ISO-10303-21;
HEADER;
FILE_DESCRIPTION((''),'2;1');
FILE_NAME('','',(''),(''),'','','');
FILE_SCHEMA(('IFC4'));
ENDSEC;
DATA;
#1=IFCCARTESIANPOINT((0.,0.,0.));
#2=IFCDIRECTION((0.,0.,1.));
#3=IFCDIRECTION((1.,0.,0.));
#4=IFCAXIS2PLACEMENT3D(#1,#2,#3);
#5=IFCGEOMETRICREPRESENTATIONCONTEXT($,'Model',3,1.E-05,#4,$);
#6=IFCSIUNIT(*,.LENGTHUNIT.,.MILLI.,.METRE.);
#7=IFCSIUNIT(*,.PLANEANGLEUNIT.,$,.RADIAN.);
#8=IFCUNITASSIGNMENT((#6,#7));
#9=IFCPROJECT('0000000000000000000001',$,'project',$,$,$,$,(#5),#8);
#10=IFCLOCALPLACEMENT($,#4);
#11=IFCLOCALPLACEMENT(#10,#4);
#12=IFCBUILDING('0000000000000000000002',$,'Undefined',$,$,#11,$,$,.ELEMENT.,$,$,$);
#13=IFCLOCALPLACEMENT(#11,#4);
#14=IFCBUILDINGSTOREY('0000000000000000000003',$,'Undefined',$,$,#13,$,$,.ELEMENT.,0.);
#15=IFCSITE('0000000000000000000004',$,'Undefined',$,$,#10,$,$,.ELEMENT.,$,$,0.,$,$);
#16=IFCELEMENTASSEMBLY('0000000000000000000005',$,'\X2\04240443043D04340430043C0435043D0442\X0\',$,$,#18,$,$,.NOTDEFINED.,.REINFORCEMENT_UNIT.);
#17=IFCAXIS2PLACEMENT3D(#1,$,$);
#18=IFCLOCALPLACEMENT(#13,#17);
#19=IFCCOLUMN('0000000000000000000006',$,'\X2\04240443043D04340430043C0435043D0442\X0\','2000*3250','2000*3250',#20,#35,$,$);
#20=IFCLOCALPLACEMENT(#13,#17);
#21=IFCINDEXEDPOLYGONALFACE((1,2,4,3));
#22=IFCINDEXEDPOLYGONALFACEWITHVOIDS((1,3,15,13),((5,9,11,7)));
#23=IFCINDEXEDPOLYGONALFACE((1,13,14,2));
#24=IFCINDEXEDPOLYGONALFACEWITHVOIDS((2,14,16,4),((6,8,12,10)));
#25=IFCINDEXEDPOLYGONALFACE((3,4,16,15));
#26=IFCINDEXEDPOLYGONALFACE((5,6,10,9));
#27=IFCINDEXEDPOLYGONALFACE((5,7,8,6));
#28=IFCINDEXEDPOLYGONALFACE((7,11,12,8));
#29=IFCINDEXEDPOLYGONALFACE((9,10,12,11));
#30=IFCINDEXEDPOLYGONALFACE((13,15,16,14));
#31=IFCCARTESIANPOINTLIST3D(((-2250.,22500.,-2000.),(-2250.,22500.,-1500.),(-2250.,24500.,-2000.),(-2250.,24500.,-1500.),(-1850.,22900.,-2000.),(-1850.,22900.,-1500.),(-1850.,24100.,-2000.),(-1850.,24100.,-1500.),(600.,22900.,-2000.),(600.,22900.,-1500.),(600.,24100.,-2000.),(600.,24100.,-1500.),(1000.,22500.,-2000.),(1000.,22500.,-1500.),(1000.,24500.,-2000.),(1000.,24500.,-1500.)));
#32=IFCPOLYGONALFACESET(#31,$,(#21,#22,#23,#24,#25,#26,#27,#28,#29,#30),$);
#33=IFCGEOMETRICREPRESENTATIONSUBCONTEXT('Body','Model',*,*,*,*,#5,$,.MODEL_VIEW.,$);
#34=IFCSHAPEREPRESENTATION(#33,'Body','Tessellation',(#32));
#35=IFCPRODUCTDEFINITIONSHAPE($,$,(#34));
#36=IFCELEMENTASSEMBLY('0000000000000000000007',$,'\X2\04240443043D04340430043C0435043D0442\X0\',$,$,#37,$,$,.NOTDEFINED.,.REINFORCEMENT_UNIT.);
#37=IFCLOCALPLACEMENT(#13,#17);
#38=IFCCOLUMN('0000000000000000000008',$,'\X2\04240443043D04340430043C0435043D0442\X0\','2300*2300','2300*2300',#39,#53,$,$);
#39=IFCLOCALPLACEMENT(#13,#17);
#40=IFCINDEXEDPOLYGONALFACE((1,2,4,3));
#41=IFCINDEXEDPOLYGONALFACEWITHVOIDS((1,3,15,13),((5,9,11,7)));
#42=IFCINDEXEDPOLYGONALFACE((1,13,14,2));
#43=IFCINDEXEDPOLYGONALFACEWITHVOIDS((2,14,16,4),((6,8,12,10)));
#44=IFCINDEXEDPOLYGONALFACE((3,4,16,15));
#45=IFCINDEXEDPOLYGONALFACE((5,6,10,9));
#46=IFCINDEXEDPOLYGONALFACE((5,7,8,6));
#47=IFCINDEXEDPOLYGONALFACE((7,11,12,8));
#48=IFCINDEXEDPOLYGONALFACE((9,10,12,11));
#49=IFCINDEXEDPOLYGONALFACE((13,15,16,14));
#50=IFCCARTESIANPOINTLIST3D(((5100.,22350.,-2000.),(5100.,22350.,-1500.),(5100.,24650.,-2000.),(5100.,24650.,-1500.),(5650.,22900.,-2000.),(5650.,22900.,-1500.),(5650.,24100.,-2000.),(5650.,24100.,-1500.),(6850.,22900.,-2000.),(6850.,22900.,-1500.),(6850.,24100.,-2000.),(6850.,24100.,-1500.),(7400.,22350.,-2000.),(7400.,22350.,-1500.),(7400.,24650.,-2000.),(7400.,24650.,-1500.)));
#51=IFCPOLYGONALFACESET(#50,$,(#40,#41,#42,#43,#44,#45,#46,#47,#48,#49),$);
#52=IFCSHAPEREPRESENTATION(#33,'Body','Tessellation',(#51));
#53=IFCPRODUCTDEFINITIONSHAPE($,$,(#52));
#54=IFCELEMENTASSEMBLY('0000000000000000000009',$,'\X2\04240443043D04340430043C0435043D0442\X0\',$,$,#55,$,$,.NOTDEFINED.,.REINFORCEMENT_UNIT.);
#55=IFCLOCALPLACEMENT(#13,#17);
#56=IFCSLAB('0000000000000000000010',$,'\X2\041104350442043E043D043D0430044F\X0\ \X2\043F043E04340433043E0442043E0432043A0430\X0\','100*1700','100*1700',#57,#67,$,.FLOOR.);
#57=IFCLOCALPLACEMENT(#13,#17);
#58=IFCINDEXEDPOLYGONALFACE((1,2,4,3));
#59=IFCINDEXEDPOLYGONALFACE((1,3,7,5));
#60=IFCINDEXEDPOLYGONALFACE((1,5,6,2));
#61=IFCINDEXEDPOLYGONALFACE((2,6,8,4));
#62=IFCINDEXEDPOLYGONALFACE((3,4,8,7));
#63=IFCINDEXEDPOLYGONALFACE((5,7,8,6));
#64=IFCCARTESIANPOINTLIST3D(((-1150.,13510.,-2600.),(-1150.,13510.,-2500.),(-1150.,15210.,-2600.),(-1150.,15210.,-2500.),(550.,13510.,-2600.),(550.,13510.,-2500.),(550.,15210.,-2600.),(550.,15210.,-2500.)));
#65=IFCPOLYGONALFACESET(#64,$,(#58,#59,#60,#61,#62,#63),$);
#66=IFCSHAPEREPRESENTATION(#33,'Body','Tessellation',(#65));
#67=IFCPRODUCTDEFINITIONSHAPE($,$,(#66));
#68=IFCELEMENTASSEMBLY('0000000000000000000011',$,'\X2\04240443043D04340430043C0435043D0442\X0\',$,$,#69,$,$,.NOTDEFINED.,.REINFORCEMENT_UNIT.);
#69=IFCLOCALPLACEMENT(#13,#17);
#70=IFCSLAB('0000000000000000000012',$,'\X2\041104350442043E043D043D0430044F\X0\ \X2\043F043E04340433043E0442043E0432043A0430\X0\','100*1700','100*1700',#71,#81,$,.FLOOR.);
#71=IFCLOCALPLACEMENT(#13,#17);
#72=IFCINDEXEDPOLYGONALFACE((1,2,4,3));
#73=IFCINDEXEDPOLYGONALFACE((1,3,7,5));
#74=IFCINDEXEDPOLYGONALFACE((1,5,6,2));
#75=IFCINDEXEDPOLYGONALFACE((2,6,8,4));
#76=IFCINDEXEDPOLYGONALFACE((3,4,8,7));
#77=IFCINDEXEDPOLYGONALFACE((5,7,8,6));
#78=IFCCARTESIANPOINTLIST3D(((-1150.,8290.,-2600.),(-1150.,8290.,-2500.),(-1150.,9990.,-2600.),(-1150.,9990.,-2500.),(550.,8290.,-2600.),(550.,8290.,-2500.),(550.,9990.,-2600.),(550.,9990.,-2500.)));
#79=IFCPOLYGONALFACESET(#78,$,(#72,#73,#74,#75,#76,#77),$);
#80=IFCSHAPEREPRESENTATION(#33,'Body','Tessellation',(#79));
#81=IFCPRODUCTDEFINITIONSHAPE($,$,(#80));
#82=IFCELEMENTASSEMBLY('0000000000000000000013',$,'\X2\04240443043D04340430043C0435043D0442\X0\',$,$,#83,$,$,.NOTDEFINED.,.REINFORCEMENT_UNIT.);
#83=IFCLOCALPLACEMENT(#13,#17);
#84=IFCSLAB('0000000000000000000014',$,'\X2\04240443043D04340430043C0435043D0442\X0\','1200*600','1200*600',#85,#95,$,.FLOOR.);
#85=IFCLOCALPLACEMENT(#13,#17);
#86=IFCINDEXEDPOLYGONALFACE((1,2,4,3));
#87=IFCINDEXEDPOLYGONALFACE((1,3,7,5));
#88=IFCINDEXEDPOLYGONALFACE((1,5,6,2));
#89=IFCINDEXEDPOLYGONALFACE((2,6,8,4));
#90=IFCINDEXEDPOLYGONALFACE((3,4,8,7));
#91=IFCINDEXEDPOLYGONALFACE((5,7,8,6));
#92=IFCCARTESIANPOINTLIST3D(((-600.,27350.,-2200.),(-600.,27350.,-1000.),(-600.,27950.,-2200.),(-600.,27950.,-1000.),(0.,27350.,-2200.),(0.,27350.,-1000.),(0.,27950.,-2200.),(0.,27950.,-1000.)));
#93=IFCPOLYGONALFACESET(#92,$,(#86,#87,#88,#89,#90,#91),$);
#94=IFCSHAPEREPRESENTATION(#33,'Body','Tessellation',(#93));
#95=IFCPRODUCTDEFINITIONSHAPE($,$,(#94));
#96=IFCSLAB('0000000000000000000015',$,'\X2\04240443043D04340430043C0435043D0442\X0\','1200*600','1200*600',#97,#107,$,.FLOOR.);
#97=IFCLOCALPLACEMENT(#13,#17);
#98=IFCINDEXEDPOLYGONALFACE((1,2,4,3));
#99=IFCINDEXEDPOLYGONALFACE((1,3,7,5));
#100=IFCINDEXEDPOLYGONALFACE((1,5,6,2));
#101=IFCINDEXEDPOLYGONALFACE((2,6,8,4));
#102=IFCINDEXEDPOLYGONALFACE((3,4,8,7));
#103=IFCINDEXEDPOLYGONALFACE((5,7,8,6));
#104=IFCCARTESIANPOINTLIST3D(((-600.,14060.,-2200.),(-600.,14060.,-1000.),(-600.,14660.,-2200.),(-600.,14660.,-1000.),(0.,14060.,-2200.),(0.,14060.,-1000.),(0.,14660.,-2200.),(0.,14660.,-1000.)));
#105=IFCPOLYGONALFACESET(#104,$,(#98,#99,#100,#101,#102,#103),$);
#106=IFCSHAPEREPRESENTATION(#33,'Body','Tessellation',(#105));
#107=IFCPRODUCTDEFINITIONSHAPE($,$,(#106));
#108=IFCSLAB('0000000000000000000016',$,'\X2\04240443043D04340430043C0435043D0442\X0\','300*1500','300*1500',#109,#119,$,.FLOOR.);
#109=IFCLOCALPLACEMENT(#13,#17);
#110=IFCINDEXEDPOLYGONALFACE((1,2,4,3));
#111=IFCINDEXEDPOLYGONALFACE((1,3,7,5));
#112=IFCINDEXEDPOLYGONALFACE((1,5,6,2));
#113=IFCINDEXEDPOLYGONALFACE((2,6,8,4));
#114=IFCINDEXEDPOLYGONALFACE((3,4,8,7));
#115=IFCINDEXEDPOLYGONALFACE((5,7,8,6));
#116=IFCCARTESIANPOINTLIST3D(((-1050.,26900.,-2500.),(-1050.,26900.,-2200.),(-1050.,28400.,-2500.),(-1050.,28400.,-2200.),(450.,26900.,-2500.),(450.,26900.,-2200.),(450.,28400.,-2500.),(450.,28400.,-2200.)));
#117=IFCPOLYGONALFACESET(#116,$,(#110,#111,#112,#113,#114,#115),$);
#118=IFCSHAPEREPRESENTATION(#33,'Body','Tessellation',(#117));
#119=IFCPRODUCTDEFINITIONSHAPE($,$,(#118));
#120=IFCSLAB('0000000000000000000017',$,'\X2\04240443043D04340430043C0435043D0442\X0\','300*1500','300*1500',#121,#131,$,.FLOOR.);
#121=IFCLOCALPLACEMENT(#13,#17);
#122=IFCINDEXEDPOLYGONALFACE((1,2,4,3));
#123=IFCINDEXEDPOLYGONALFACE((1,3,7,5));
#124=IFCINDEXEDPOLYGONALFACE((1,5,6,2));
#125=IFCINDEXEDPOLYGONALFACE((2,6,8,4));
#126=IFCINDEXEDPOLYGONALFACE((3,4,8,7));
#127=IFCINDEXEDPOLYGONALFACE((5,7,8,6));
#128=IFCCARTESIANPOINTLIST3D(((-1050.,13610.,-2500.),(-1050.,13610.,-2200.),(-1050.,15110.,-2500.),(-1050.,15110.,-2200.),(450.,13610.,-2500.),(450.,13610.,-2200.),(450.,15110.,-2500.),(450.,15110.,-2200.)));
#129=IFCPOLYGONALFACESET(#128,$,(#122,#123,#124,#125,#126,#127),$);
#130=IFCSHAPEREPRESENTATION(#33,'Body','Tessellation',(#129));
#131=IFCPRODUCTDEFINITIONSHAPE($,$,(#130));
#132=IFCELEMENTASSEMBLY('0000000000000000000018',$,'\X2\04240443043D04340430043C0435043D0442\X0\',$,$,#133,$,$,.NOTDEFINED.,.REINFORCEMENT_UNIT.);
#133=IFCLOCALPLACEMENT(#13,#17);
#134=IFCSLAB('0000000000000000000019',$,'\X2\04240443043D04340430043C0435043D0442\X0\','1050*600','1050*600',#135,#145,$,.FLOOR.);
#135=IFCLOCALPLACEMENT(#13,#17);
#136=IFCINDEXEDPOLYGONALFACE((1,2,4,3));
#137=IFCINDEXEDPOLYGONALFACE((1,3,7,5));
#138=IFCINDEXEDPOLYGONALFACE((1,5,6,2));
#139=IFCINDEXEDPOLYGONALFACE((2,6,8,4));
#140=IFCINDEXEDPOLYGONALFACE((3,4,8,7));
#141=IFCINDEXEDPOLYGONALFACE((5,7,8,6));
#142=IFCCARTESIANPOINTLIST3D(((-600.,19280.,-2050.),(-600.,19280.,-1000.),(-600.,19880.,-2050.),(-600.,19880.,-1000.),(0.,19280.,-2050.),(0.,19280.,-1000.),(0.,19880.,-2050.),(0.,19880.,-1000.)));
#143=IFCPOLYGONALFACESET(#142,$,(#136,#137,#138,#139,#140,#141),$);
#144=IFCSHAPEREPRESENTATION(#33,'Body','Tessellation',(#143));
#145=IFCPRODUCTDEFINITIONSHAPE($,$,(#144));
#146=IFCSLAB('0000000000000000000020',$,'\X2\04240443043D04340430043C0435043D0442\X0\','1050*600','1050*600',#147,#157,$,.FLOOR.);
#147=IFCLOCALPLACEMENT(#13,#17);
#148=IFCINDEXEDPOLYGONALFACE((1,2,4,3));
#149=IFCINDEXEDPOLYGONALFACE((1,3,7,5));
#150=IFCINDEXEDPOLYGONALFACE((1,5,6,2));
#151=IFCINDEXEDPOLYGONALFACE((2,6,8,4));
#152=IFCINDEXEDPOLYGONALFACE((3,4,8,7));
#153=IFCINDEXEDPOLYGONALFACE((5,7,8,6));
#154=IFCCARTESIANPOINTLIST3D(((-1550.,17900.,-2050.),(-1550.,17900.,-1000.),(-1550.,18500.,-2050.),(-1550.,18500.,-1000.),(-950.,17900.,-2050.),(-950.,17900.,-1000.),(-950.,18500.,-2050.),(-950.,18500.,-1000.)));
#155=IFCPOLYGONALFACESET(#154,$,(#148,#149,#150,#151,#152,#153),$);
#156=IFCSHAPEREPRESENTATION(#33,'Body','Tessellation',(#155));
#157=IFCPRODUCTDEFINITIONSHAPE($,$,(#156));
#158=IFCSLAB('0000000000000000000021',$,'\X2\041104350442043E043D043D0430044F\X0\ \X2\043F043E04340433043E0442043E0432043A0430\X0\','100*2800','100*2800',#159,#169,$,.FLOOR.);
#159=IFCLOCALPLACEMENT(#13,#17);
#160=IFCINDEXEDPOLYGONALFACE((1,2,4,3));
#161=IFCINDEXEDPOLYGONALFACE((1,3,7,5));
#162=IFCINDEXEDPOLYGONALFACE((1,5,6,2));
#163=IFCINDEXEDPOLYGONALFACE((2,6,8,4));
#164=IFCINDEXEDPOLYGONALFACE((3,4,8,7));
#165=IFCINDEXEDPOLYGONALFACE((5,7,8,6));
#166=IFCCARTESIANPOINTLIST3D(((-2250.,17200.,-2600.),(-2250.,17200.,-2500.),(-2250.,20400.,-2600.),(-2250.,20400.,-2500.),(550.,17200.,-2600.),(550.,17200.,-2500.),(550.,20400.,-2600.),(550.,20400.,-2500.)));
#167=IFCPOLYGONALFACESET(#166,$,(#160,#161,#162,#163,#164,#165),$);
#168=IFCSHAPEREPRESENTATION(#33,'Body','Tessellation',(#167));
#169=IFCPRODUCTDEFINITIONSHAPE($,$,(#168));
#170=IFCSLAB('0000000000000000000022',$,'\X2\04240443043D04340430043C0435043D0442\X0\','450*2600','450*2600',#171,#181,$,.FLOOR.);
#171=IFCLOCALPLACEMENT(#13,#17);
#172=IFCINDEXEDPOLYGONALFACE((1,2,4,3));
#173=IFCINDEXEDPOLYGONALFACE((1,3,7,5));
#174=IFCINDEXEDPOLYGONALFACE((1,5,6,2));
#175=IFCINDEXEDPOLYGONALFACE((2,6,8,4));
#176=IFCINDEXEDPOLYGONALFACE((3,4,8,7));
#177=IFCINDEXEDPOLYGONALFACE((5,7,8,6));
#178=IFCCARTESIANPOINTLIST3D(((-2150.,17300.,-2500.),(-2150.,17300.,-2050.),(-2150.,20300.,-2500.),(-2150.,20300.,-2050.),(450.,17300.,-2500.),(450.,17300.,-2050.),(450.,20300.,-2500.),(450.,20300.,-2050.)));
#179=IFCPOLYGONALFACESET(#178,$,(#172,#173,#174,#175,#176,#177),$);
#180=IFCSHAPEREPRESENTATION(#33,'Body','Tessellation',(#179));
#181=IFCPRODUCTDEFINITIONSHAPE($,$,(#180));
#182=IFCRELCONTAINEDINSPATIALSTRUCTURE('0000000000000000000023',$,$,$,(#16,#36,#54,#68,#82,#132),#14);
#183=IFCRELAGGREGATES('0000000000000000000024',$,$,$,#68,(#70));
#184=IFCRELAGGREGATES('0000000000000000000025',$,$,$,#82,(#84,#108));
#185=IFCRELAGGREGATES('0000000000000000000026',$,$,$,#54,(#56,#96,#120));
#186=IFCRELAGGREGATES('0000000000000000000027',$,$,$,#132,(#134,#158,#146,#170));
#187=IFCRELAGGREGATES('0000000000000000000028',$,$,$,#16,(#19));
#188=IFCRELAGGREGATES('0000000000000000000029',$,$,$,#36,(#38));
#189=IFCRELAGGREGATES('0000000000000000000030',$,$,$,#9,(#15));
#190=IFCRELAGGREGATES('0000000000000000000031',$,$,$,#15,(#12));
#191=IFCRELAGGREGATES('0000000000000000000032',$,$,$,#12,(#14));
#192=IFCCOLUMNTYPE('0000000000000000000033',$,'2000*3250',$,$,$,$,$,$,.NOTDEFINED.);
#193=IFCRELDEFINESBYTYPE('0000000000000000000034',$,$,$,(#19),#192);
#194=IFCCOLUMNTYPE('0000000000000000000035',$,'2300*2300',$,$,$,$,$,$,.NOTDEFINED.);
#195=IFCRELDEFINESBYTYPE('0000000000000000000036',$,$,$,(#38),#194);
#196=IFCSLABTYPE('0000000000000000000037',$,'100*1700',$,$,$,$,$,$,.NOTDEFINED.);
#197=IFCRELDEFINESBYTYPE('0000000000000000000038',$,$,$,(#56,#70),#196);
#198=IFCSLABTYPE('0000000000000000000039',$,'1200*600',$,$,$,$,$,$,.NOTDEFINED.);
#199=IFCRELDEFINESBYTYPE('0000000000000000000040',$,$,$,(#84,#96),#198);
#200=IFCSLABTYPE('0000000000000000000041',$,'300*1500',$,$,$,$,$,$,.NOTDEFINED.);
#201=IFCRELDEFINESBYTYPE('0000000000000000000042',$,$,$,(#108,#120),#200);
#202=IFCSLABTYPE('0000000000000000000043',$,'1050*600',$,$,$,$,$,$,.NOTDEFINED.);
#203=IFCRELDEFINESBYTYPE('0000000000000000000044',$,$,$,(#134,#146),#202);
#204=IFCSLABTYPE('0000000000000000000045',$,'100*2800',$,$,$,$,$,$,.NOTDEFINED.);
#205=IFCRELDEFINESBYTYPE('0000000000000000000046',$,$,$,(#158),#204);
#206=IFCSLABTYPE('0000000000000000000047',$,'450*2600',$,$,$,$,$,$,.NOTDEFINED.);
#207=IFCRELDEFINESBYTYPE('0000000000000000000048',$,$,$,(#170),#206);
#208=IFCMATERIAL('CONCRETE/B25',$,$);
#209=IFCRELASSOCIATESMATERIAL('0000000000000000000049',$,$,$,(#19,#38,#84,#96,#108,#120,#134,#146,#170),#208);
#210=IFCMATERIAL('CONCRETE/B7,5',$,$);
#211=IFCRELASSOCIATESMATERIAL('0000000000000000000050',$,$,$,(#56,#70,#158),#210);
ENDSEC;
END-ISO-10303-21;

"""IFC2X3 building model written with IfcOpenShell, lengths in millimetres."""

from ifc_helpers import new_model, si_unit, frame, origin_with_axes, origin_2d_with_axis, place, context, subcontext, project, spatial, polyline, rectangle, outline, extrude, boolean, material, type_object, element, aggregate, save


model = new_model("IFC2X3")

# Units and contexts
model_context = context("Model", 3, precision=1e-05, world=origin_with_axes())
body_context = subcontext(model_context, "Body", "Model", "MODEL_VIEW")
ifc_project = project(units=[si_unit("LENGTHUNIT", "METRE", prefix="MILLI"), si_unit("PLANEANGLEUNIT", "RADIAN")], contexts=[model_context])

# Site, building, storey
site_placement = place(None, origin_with_axes())
site = spatial("IfcSite", under=ifc_project, at=site_placement, Name="Undefined", CompositionType="ELEMENT", RefElevation=0.0)
building_placement = place(site_placement, origin_with_axes())
building = spatial("IfcBuilding", under=site, at=building_placement, Name="Undefined", CompositionType="ELEMENT")
storey_placement = place(building_placement, origin_with_axes())
storey = spatial("IfcBuildingStorey", under=building, at=storey_placement, Name="Undefined", CompositionType="ELEMENT", Elevation=0.0)

# Element assemblies, columns
assembly_1_placement = place(storey_placement, origin_with_axes())
assembly_1 = element("IfcElementAssembly", 1, at=assembly_1_placement, inside=storey, Name="Фундамент", AssemblyPlace="NOTDEFINED", PredefinedType="REINFORCEMENT_UNIT")
ifc_material_1 = material(Name="CONCRETE/B25")
column_type_1 = type_object("IfcColumnType", Name="2000*3250", PredefinedType="NOTDEFINED")
column_1_placement = place(assembly_1_placement, frame((-625.0, 23500.0, -2000.0), z_axis=(0.0, 0.0, 1.0), x_axis=(0.0, -1.0, 0.0)))
column_1 = element("IfcColumn", 2, at=column_1_placement, type_object=column_type_1, material=ifc_material_1, Name="Фундамент", Description="2000*3250", ObjectType="2000*3250", context=body_context, shape_type="CSG", body=[
    boolean("DIFFERENCE", extrude(rectangle(XDim=3250.0, YDim=2000.0, at=origin_2d_with_axis()), frame((0.0, 0.0, 500.0), z_axis=(0.0, 0.0, -1.0), x_axis=(0.0, 1.0, 0.0)), (0.0, 0.0, 1.0), 500.0), extrude(outline(polyline([(0.0, 0.0), (1200.0, 0.0), (1200.0, 2450.0), (0.0, 2450.0), (0.0, 0.0)])), frame((-600.0, -1225.0, -100.0), z_axis=(0.0, 0.0, 1.0), x_axis=(1.0, 0.0, 0.0)), (0.0, 0.0, 1.0), 700.0)),
])
assembly_2_placement = place(storey_placement, origin_with_axes())
assembly_2 = element("IfcElementAssembly", 3, at=assembly_2_placement, inside=storey, Name="Фундамент", AssemblyPlace="NOTDEFINED", PredefinedType="REINFORCEMENT_UNIT")
column_type_2 = type_object("IfcColumnType", Name="2300*2300", PredefinedType="NOTDEFINED")
column_2_placement = place(assembly_2_placement, frame((6250.0, 23500.0, -2000.0), z_axis=(0.0, 0.0, 1.0), x_axis=(0.0, -1.0, 0.0)))
column_2 = element("IfcColumn", 4, at=column_2_placement, type_object=column_type_2, material=ifc_material_1, Name="Фундамент", Description="2300*2300", ObjectType="2300*2300", context=body_context, shape_type="CSG", body=[
    boolean("DIFFERENCE", extrude(rectangle(XDim=2300.0, YDim=2300.0, at=origin_2d_with_axis()), frame((0.0, 0.0, 500.0), z_axis=(0.0, 0.0, -1.0), x_axis=(0.0, 1.0, 0.0)), (0.0, 0.0, 1.0), 500.0), extrude(outline(polyline([(0.0, 0.0), (1200.0, 0.0), (1200.0, 1200.0), (0.0, 1200.0), (0.0, 0.0)])), frame((-600.0, -600.0, -100.0), z_axis=(0.0, 0.0, 1.0), x_axis=(1.0, 0.0, 0.0)), (0.0, 0.0, 1.0), 700.0)),
])

# Element assemblies, slabs
assembly_3_placement = place(storey_placement, origin_with_axes())
assembly_3 = element("IfcElementAssembly", 5, at=assembly_3_placement, inside=storey, Name="Фундамент", AssemblyPlace="NOTDEFINED", PredefinedType="REINFORCEMENT_UNIT")
ifc_material_2 = material(Name="CONCRETE/B7,5")
slab_type_1 = type_object("IfcSlabType", Name="100*1700", PredefinedType="NOTDEFINED")
slab_1_placement = place(assembly_3_placement, frame((-1150.0, 15210.0, -2550.0), z_axis=(0.0, 0.0, 1.0), x_axis=(0.0, -1.0, 0.0)))
slab_1 = element("IfcSlab", 6, at=slab_1_placement, type_object=slab_type_1, material=ifc_material_2, Name="Бетонная подготовка", Description="100*1700", ObjectType="100*1700", PredefinedType="FLOOR", context=body_context, shape_type="SweptSolid", body=[
    extrude(outline(polyline([(0.0, 0.0), (1700.0, 0.0), (1700.0, 1700.0), (0.0, 1700.0), (0.0, 0.0)])), frame((0.0, 0.0, -50.0), z_axis=(0.0, 0.0, 1.0), x_axis=(1.0, 0.0, 0.0)), (0.0, 0.0, 1.0), 100.0),
])
assembly_4_placement = place(storey_placement, origin_with_axes())
assembly_4 = element("IfcElementAssembly", 7, at=assembly_4_placement, inside=storey, Name="Фундамент", AssemblyPlace="NOTDEFINED", PredefinedType="REINFORCEMENT_UNIT")
slab_2_placement = place(assembly_4_placement, frame((-1150.0, 9990.0, -2550.0), z_axis=(0.0, 0.0, 1.0), x_axis=(0.0, -1.0, 0.0)))
slab_2 = element("IfcSlab", 8, at=slab_2_placement, type_object=slab_type_1, material=ifc_material_2, Name="Бетонная подготовка", Description="100*1700", ObjectType="100*1700", PredefinedType="FLOOR", context=body_context, shape_type="SweptSolid", body=[
    extrude(outline(polyline([(0.0, 0.0), (1700.0, 0.0), (1700.0, 1700.0), (0.0, 1700.0), (0.0, 0.0)])), frame((0.0, 0.0, -50.0), z_axis=(0.0, 0.0, 1.0), x_axis=(1.0, 0.0, 0.0)), (0.0, 0.0, 1.0), 100.0),
])
aggregate(assembly_4, [slab_2])
assembly_5_placement = place(storey_placement, origin_with_axes())
assembly_5 = element("IfcElementAssembly", 9, at=assembly_5_placement, inside=storey, Name="Фундамент", AssemblyPlace="NOTDEFINED", PredefinedType="REINFORCEMENT_UNIT")
slab_type_2 = type_object("IfcSlabType", Name="1200*600", PredefinedType="NOTDEFINED")
slab_3_placement = place(assembly_5_placement, frame((-600.0, 27950.0, -1600.0), z_axis=(0.0, 0.0, 1.0), x_axis=(0.0, -1.0, 0.0)))
slab_3 = element("IfcSlab", 10, at=slab_3_placement, type_object=slab_type_2, material=ifc_material_1, Name="Фундамент", Description="1200*600", ObjectType="1200*600", PredefinedType="FLOOR", context=body_context, shape_type="SweptSolid", body=[
    extrude(outline(polyline([(0.0, 0.0), (600.0, 0.0), (600.0, 600.0), (0.0, 600.0), (0.0, 0.0)])), frame((0.0, 0.0, -600.0), z_axis=(0.0, 0.0, 1.0), x_axis=(1.0, 0.0, 0.0)), (0.0, 0.0, 1.0), 1200.0),
])

# Slabs
slab_4_placement = place(assembly_3_placement, frame((-600.0, 14660.0, -1600.0), z_axis=(0.0, 0.0, 1.0), x_axis=(0.0, -1.0, 0.0)))
slab_4 = element("IfcSlab", 11, at=slab_4_placement, type_object=slab_type_2, material=ifc_material_1, Name="Фундамент", Description="1200*600", ObjectType="1200*600", PredefinedType="FLOOR", context=body_context, shape_type="SweptSolid", body=[
    extrude(outline(polyline([(0.0, 0.0), (600.0, 0.0), (600.0, 600.0), (0.0, 600.0), (0.0, 0.0)])), frame((0.0, 0.0, -600.0), z_axis=(0.0, 0.0, 1.0), x_axis=(1.0, 0.0, 0.0)), (0.0, 0.0, 1.0), 1200.0),
])
slab_type_3 = type_object("IfcSlabType", Name="300*1500", PredefinedType="NOTDEFINED")
slab_5_placement = place(assembly_5_placement, frame((-1050.0, 28400.0, -2350.0), z_axis=(0.0, 0.0, 1.0), x_axis=(0.0, -1.0, 0.0)))
slab_5 = element("IfcSlab", 12, at=slab_5_placement, type_object=slab_type_3, material=ifc_material_1, Name="Фундамент", Description="300*1500", ObjectType="300*1500", PredefinedType="FLOOR", context=body_context, shape_type="SweptSolid", body=[
    extrude(outline(polyline([(0.0, 0.0), (1500.0, 0.0), (1500.0, 1500.0), (0.0, 1500.0), (0.0, 0.0)])), frame((0.0, 0.0, -150.0), z_axis=(0.0, 0.0, 1.0), x_axis=(1.0, 0.0, 0.0)), (0.0, 0.0, 1.0), 300.0),
])
aggregate(assembly_5, [slab_3, slab_5])
slab_6_placement = place(assembly_3_placement, frame((-1050.0, 15110.0, -2350.0), z_axis=(0.0, 0.0, 1.0), x_axis=(0.0, -1.0, 0.0)))
slab_6 = element("IfcSlab", 13, at=slab_6_placement, type_object=slab_type_3, material=ifc_material_1, Name="Фундамент", Description="300*1500", ObjectType="300*1500", PredefinedType="FLOOR", context=body_context, shape_type="SweptSolid", body=[
    extrude(outline(polyline([(0.0, 0.0), (1500.0, 0.0), (1500.0, 1500.0), (0.0, 1500.0), (0.0, 0.0)])), frame((0.0, 0.0, -150.0), z_axis=(0.0, 0.0, 1.0), x_axis=(1.0, 0.0, 0.0)), (0.0, 0.0, 1.0), 300.0),
])
aggregate(assembly_3, [slab_1, slab_4, slab_6])

# Element assembly, slabs
assembly_6_placement = place(storey_placement, origin_with_axes())
assembly_6 = element("IfcElementAssembly", 14, at=assembly_6_placement, inside=storey, Name="Фундамент", AssemblyPlace="NOTDEFINED", PredefinedType="REINFORCEMENT_UNIT")
slab_type_4 = type_object("IfcSlabType", Name="1050*600", PredefinedType="NOTDEFINED")
slab_7_placement = place(assembly_6_placement, frame((-600.0, 19880.0, -1525.0), z_axis=(0.0, 0.0, 1.0), x_axis=(0.0, -1.0, 0.0)))
slab_7 = element("IfcSlab", 15, at=slab_7_placement, type_object=slab_type_4, material=ifc_material_1, Name="Фундамент", Description="1050*600", ObjectType="1050*600", PredefinedType="FLOOR", context=body_context, shape_type="SweptSolid", body=[
    extrude(outline(polyline([(0.0, 0.0), (600.0, 0.0), (600.0, 600.0), (0.0, 600.0), (0.0, 0.0)])), frame((0.0, 0.0, -525.0), z_axis=(0.0, 0.0, 1.0), x_axis=(1.0, 0.0, 0.0)), (0.0, 0.0, 1.0), 1050.0),
])
slab_8_placement = place(assembly_6_placement, frame((-1550.0, 18500.0, -1525.0), z_axis=(0.0, 0.0, 1.0), x_axis=(0.0, -1.0, 0.0)))
slab_8 = element("IfcSlab", 16, at=slab_8_placement, type_object=slab_type_4, material=ifc_material_1, Name="Фундамент", Description="1050*600", ObjectType="1050*600", PredefinedType="FLOOR", context=body_context, shape_type="SweptSolid", body=[
    extrude(outline(polyline([(0.0, 0.0), (600.0, 0.0), (600.0, 600.0), (0.0, 600.0), (0.0, 0.0)])), frame((0.0, 0.0, -525.0), z_axis=(0.0, 0.0, 1.0), x_axis=(1.0, 0.0, 0.0)), (0.0, 0.0, 1.0), 1050.0),
])
slab_type_5 = type_object("IfcSlabType", Name="100*2800", PredefinedType="NOTDEFINED")
slab_9_placement = place(assembly_6_placement, frame((-2250.0, 20400.0, -2550.0), z_axis=(0.0, 0.0, 1.0), x_axis=(0.0, -1.0, 0.0)))
slab_9 = element("IfcSlab", 17, at=slab_9_placement, type_object=slab_type_5, material=ifc_material_2, Name="Бетонная подготовка", Description="100*2800", ObjectType="100*2800", PredefinedType="FLOOR", context=body_context, shape_type="SweptSolid", body=[
    extrude(outline(polyline([(0.0, 0.0), (3200.0, 0.0), (3200.0, 2800.0), (0.0, 2800.0), (0.0, 0.0)])), frame((0.0, 0.0, -50.0), z_axis=(0.0, 0.0, 1.0), x_axis=(1.0, 0.0, 0.0)), (0.0, 0.0, 1.0), 100.0),
])
slab_type_6 = type_object("IfcSlabType", Name="450*2600", PredefinedType="NOTDEFINED")
slab_10_placement = place(assembly_6_placement, frame((-2150.0, 20300.0, -2275.0), z_axis=(0.0, 0.0, 1.0), x_axis=(0.0, -1.0, 0.0)))
slab_10 = element("IfcSlab", 18, at=slab_10_placement, type_object=slab_type_6, material=ifc_material_1, Name="Фундамент", Description="450*2600", ObjectType="450*2600", PredefinedType="FLOOR", context=body_context, shape_type="SweptSolid", body=[
    extrude(outline(polyline([(0.0, 0.0), (3000.0, 0.0), (3000.0, 2600.0), (0.0, 2600.0), (0.0, 0.0)])), frame((0.0, 0.0, -225.0), z_axis=(0.0, 0.0, 1.0), x_axis=(1.0, 0.0, 0.0)), (0.0, 0.0, 1.0), 450.0),
])
aggregate(assembly_6, [slab_7, slab_9, slab_8, slab_10])

aggregate(assembly_1, [column_1])

aggregate(assembly_2, [column_2])

save(model, "model.ifc")
